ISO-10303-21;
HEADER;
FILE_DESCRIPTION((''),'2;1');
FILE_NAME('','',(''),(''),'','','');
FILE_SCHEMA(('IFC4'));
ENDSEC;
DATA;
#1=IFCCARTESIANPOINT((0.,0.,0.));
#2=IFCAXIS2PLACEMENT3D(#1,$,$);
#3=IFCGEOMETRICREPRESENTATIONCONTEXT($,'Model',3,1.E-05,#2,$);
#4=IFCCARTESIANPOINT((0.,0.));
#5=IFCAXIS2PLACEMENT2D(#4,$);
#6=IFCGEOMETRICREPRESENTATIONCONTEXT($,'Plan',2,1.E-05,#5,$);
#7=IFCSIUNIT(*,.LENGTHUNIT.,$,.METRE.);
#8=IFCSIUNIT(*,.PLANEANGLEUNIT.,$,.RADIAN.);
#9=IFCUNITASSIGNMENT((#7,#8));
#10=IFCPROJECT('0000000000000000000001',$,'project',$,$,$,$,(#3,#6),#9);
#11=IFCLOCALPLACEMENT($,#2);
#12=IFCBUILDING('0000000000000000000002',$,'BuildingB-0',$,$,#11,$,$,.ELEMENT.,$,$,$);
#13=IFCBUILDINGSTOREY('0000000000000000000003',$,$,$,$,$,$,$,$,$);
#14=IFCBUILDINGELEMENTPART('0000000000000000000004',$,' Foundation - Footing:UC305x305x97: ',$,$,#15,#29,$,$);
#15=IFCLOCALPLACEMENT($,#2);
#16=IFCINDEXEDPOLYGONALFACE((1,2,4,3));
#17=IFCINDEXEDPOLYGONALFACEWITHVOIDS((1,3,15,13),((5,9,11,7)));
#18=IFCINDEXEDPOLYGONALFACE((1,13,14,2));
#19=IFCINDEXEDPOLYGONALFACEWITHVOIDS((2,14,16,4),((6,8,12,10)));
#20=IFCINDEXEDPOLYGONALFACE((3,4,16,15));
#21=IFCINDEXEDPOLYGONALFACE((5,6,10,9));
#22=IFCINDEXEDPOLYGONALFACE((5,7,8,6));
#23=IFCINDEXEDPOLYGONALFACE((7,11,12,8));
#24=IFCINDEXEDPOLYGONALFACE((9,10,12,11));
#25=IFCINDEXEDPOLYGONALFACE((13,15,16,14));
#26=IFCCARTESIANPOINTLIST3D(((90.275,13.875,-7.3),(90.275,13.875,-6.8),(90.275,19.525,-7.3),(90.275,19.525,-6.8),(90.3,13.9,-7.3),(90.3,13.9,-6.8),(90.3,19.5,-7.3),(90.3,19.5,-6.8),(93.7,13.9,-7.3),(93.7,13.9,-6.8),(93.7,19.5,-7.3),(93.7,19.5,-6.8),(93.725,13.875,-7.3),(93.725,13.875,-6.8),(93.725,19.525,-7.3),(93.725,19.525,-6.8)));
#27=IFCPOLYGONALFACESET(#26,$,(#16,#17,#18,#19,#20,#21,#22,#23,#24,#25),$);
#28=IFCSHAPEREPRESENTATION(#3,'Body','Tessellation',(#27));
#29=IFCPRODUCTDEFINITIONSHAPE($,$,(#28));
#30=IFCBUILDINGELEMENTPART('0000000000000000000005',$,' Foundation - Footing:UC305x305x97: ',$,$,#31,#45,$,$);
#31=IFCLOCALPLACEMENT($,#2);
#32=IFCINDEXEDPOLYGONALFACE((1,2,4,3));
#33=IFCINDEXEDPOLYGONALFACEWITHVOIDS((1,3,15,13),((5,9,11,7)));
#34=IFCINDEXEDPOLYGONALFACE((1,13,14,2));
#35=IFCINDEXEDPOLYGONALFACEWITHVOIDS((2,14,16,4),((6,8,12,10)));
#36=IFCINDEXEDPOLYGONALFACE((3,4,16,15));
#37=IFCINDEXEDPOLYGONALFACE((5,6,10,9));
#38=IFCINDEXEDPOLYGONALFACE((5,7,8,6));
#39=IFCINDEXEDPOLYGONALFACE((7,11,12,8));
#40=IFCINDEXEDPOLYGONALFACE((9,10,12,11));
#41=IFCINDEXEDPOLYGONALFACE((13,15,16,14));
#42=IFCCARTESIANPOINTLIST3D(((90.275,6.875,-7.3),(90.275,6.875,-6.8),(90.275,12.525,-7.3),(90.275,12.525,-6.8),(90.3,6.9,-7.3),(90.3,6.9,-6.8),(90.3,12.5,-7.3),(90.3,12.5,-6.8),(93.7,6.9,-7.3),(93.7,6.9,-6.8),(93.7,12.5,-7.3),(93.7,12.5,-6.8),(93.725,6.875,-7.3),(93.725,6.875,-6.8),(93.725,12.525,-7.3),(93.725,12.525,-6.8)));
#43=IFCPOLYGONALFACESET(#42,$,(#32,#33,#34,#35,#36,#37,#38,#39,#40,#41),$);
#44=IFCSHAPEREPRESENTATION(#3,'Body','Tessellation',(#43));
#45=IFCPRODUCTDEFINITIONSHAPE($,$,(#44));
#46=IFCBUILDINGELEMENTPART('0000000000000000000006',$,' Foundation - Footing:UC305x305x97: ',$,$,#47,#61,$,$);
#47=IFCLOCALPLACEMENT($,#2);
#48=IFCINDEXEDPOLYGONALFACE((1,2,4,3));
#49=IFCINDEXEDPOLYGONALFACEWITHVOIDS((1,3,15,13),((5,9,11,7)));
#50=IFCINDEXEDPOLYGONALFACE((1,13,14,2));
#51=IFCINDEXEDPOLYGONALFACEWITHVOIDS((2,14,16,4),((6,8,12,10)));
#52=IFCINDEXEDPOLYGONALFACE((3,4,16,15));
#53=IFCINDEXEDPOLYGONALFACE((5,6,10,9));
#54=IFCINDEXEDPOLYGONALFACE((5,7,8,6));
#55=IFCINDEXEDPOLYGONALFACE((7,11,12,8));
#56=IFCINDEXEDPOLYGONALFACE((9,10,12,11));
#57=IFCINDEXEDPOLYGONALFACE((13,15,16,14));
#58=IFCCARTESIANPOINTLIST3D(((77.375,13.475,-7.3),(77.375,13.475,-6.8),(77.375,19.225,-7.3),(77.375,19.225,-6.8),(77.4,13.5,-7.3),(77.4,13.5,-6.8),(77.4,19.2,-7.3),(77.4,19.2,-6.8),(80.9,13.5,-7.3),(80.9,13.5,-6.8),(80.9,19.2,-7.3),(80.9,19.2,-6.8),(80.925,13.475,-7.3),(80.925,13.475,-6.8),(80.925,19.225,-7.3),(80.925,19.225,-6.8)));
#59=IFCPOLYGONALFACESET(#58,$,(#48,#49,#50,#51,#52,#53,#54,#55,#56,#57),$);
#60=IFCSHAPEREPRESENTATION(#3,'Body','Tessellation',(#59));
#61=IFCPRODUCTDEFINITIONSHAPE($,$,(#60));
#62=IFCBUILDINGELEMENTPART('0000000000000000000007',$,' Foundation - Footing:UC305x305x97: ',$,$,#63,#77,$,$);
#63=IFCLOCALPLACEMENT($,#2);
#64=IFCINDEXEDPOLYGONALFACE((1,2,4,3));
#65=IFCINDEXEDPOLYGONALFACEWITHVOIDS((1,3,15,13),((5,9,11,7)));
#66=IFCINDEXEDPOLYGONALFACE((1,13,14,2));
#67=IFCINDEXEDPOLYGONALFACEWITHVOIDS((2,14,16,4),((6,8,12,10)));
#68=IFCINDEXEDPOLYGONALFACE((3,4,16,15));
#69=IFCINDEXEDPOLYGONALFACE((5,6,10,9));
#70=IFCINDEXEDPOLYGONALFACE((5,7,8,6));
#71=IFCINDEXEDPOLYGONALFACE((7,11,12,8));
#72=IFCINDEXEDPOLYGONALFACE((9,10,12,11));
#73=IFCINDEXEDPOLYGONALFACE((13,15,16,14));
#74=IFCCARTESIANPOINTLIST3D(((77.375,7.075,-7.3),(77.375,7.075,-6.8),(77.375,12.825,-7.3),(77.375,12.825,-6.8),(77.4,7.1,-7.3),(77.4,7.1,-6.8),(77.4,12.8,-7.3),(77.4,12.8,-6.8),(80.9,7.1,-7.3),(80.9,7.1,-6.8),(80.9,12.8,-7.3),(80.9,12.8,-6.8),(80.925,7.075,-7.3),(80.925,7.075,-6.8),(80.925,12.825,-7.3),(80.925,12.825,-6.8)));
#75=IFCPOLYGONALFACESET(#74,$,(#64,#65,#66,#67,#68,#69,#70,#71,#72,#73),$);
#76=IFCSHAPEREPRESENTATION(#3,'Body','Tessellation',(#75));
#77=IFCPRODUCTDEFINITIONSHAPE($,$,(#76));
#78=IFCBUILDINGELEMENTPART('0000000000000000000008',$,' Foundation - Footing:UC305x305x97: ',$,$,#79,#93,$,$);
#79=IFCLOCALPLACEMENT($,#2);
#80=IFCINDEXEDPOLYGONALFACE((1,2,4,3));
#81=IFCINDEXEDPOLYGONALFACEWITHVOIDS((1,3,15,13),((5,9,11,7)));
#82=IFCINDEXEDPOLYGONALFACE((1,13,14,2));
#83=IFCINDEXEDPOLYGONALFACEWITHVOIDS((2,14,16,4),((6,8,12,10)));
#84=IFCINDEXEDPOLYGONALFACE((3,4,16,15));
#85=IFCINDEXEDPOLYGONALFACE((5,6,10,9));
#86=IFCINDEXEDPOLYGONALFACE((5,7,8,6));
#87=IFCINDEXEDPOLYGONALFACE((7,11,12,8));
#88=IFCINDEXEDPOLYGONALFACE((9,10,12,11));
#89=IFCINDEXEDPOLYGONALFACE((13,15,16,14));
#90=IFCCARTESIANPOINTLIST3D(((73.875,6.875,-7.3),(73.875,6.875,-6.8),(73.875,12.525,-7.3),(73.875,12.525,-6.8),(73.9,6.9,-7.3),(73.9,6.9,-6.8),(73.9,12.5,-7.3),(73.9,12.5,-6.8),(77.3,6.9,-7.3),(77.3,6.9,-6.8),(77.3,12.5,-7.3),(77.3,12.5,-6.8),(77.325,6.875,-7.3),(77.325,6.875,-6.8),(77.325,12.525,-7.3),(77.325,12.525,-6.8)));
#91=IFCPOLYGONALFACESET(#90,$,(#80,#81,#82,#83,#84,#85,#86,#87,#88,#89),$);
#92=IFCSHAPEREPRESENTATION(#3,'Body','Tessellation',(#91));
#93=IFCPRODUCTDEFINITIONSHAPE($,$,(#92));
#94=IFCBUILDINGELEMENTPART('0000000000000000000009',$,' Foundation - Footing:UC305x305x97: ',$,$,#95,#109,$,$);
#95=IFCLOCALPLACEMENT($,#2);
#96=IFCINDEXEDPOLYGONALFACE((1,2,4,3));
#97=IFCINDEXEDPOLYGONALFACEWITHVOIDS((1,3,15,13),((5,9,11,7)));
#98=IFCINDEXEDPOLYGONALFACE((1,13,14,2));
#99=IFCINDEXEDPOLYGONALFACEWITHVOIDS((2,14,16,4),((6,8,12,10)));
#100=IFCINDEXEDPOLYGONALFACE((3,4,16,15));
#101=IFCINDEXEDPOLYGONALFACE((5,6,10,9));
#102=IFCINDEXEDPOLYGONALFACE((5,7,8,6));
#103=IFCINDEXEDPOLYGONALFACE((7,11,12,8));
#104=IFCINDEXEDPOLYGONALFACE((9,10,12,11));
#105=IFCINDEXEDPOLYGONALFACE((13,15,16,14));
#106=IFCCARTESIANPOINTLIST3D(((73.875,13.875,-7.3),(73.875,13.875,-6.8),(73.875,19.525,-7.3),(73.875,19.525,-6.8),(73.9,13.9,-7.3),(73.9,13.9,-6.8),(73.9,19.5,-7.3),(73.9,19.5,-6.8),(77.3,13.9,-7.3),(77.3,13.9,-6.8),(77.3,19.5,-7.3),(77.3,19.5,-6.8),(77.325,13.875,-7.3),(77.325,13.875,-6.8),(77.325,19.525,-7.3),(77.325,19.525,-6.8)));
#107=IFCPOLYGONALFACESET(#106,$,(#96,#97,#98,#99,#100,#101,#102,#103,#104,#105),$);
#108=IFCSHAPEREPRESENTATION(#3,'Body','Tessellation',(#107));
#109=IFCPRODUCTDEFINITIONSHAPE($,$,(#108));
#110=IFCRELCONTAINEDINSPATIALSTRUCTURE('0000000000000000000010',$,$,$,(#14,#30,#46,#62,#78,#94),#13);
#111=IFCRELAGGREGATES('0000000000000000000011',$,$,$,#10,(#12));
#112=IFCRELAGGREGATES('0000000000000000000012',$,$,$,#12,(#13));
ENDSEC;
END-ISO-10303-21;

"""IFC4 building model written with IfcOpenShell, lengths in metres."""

from ifc_helpers import new_model, si_unit, origin, origin_2d, place, context, project, spatial, polyline, outline, extrude, element, save


model = new_model("IFC4")

# Units and contexts
model_context = context("Model", 3, precision=1e-05, world=origin())
plan_context = context("Plan", 2, precision=1e-05, world=origin_2d())
ifc_project = project(units=[si_unit("LENGTHUNIT", "METRE"), si_unit("PLANEANGLEUNIT", "RADIAN")], contexts=[model_context, plan_context])

# Building, storey
building_placement = place(None, origin())
building = spatial("IfcBuilding", under=ifc_project, at=building_placement, Name="BuildingB-0", CompositionType="ELEMENT")
storey = spatial("IfcBuildingStorey", under=building)

# Building element parts, openings
building_element_part_1 = element("IfcBuildingElementPart", 1, inside=storey, Name=" Foundation - Footing:UC305x305x97: ", context=model_context, shape_type="SweptSolid", body=[
    extrude(outline(polyline([(90.275, 19.525, -7.3), (93.725, 19.525, -7.3), (93.725, 13.875, -7.3), (90.275, 13.875, -7.3), (90.275, 19.525, -7.3)])), None, (0.0, 0.0, 1.0), 0.5),
])
element("IfcOpeningElement", 2, inside=storey, cuts=building_element_part_1, context=model_context, shape_type="SweptSolid", body=[
    extrude(outline(polyline([(90.3, 19.5, -7.3), (93.7, 19.5, -7.3), (93.7, 13.9, -7.3), (90.3, 13.9, -7.3), (90.3, 19.5, -7.3)])), None, (0.0, 0.0, 1.0), 0.5),
])
building_element_part_2 = element("IfcBuildingElementPart", 3, inside=storey, Name=" Foundation - Footing:UC305x305x97: ", context=model_context, shape_type="SweptSolid", body=[
    extrude(outline(polyline([(90.275, 12.525, -7.3), (93.725, 12.525, -7.3), (93.725, 6.875, -7.3), (90.275, 6.875, -7.3), (90.275, 12.525, -7.3)])), None, (0.0, 0.0, 1.0), 0.5),
])
element("IfcOpeningElement", 4, inside=storey, cuts=building_element_part_2, context=model_context, shape_type="SweptSolid", body=[
    extrude(outline(polyline([(90.3, 12.5, -7.3), (93.7, 12.5, -7.3), (93.7, 6.9, -7.3), (90.3, 6.9, -7.3), (90.3, 12.5, -7.3)])), None, (0.0, 0.0, 1.0), 0.5),
])
building_element_part_3 = element("IfcBuildingElementPart", 5, inside=storey, Name=" Foundation - Footing:UC305x305x97: ", context=model_context, shape_type="SweptSolid", body=[
    extrude(outline(polyline([(77.375, 19.225, -7.3), (80.925, 19.225, -7.3), (80.925, 13.475, -7.3), (77.375, 13.475, -7.3), (77.375, 19.225, -7.3)])), None, (0.0, 0.0, 1.0), 0.5),
])
element("IfcOpeningElement", 6, inside=storey, cuts=building_element_part_3, context=model_context, shape_type="SweptSolid", body=[
    extrude(outline(polyline([(77.4, 19.2, -7.3), (80.9, 19.2, -7.3), (80.9, 13.5, -7.3), (77.4, 13.5, -7.3), (77.4, 19.2, -7.3)])), None, (0.0, 0.0, 1.0), 0.5),
])
building_element_part_4 = element("IfcBuildingElementPart", 7, inside=storey, Name=" Foundation - Footing:UC305x305x97: ", context=model_context, shape_type="SweptSolid", body=[
    extrude(outline(polyline([(77.375, 12.825, -7.3), (80.925, 12.825, -7.3), (80.925, 7.075, -7.3), (77.375, 7.075, -7.3), (77.375, 12.825, -7.3)])), None, (0.0, 0.0, 1.0), 0.5),
])
element("IfcOpeningElement", 8, inside=storey, cuts=building_element_part_4, context=model_context, shape_type="SweptSolid", body=[
    extrude(outline(polyline([(77.4, 12.8, -7.3), (80.9, 12.8, -7.3), (80.9, 7.1, -7.3), (77.4, 7.1, -7.3), (77.4, 12.8, -7.3)])), None, (0.0, 0.0, 1.0), 0.5),
])
building_element_part_5 = element("IfcBuildingElementPart", 9, inside=storey, Name=" Foundation - Footing:UC305x305x97: ", context=model_context, shape_type="SweptSolid", body=[
    extrude(outline(polyline([(73.875, 12.525, -7.3), (77.325, 12.525, -7.3), (77.325, 6.875, -7.3), (73.875, 6.875, -7.3), (73.875, 12.525, -7.3)])), None, (0.0, 0.0, 1.0), 0.5),
])
element("IfcOpeningElement", 10, inside=storey, cuts=building_element_part_5, context=model_context, shape_type="SweptSolid", body=[
    extrude(outline(polyline([(73.9, 12.5, -7.3), (77.3, 12.5, -7.3), (77.3, 6.9, -7.3), (73.9, 6.9, -7.3), (73.9, 12.5, -7.3)])), None, (0.0, 0.0, 1.0), 0.5),
])
building_element_part_6 = element("IfcBuildingElementPart", 11, inside=storey, Name=" Foundation - Footing:UC305x305x97: ", context=model_context, shape_type="SweptSolid", body=[
    extrude(outline(polyline([(73.875, 19.525, -7.3), (77.325, 19.525, -7.3), (77.325, 13.875, -7.3), (73.875, 13.875, -7.3), (73.875, 19.525, -7.3)])), None, (0.0, 0.0, 1.0), 0.5),
])
element("IfcOpeningElement", 12, inside=storey, cuts=building_element_part_6, context=model_context, shape_type="SweptSolid", body=[
    extrude(outline(polyline([(73.9, 19.5, -7.3), (77.3, 19.5, -7.3), (77.3, 13.9, -7.3), (73.9, 13.9, -7.3), (73.9, 19.5, -7.3)])), None, (0.0, 0.0, 1.0), 0.5),
])

save(model, "model.ifc")
